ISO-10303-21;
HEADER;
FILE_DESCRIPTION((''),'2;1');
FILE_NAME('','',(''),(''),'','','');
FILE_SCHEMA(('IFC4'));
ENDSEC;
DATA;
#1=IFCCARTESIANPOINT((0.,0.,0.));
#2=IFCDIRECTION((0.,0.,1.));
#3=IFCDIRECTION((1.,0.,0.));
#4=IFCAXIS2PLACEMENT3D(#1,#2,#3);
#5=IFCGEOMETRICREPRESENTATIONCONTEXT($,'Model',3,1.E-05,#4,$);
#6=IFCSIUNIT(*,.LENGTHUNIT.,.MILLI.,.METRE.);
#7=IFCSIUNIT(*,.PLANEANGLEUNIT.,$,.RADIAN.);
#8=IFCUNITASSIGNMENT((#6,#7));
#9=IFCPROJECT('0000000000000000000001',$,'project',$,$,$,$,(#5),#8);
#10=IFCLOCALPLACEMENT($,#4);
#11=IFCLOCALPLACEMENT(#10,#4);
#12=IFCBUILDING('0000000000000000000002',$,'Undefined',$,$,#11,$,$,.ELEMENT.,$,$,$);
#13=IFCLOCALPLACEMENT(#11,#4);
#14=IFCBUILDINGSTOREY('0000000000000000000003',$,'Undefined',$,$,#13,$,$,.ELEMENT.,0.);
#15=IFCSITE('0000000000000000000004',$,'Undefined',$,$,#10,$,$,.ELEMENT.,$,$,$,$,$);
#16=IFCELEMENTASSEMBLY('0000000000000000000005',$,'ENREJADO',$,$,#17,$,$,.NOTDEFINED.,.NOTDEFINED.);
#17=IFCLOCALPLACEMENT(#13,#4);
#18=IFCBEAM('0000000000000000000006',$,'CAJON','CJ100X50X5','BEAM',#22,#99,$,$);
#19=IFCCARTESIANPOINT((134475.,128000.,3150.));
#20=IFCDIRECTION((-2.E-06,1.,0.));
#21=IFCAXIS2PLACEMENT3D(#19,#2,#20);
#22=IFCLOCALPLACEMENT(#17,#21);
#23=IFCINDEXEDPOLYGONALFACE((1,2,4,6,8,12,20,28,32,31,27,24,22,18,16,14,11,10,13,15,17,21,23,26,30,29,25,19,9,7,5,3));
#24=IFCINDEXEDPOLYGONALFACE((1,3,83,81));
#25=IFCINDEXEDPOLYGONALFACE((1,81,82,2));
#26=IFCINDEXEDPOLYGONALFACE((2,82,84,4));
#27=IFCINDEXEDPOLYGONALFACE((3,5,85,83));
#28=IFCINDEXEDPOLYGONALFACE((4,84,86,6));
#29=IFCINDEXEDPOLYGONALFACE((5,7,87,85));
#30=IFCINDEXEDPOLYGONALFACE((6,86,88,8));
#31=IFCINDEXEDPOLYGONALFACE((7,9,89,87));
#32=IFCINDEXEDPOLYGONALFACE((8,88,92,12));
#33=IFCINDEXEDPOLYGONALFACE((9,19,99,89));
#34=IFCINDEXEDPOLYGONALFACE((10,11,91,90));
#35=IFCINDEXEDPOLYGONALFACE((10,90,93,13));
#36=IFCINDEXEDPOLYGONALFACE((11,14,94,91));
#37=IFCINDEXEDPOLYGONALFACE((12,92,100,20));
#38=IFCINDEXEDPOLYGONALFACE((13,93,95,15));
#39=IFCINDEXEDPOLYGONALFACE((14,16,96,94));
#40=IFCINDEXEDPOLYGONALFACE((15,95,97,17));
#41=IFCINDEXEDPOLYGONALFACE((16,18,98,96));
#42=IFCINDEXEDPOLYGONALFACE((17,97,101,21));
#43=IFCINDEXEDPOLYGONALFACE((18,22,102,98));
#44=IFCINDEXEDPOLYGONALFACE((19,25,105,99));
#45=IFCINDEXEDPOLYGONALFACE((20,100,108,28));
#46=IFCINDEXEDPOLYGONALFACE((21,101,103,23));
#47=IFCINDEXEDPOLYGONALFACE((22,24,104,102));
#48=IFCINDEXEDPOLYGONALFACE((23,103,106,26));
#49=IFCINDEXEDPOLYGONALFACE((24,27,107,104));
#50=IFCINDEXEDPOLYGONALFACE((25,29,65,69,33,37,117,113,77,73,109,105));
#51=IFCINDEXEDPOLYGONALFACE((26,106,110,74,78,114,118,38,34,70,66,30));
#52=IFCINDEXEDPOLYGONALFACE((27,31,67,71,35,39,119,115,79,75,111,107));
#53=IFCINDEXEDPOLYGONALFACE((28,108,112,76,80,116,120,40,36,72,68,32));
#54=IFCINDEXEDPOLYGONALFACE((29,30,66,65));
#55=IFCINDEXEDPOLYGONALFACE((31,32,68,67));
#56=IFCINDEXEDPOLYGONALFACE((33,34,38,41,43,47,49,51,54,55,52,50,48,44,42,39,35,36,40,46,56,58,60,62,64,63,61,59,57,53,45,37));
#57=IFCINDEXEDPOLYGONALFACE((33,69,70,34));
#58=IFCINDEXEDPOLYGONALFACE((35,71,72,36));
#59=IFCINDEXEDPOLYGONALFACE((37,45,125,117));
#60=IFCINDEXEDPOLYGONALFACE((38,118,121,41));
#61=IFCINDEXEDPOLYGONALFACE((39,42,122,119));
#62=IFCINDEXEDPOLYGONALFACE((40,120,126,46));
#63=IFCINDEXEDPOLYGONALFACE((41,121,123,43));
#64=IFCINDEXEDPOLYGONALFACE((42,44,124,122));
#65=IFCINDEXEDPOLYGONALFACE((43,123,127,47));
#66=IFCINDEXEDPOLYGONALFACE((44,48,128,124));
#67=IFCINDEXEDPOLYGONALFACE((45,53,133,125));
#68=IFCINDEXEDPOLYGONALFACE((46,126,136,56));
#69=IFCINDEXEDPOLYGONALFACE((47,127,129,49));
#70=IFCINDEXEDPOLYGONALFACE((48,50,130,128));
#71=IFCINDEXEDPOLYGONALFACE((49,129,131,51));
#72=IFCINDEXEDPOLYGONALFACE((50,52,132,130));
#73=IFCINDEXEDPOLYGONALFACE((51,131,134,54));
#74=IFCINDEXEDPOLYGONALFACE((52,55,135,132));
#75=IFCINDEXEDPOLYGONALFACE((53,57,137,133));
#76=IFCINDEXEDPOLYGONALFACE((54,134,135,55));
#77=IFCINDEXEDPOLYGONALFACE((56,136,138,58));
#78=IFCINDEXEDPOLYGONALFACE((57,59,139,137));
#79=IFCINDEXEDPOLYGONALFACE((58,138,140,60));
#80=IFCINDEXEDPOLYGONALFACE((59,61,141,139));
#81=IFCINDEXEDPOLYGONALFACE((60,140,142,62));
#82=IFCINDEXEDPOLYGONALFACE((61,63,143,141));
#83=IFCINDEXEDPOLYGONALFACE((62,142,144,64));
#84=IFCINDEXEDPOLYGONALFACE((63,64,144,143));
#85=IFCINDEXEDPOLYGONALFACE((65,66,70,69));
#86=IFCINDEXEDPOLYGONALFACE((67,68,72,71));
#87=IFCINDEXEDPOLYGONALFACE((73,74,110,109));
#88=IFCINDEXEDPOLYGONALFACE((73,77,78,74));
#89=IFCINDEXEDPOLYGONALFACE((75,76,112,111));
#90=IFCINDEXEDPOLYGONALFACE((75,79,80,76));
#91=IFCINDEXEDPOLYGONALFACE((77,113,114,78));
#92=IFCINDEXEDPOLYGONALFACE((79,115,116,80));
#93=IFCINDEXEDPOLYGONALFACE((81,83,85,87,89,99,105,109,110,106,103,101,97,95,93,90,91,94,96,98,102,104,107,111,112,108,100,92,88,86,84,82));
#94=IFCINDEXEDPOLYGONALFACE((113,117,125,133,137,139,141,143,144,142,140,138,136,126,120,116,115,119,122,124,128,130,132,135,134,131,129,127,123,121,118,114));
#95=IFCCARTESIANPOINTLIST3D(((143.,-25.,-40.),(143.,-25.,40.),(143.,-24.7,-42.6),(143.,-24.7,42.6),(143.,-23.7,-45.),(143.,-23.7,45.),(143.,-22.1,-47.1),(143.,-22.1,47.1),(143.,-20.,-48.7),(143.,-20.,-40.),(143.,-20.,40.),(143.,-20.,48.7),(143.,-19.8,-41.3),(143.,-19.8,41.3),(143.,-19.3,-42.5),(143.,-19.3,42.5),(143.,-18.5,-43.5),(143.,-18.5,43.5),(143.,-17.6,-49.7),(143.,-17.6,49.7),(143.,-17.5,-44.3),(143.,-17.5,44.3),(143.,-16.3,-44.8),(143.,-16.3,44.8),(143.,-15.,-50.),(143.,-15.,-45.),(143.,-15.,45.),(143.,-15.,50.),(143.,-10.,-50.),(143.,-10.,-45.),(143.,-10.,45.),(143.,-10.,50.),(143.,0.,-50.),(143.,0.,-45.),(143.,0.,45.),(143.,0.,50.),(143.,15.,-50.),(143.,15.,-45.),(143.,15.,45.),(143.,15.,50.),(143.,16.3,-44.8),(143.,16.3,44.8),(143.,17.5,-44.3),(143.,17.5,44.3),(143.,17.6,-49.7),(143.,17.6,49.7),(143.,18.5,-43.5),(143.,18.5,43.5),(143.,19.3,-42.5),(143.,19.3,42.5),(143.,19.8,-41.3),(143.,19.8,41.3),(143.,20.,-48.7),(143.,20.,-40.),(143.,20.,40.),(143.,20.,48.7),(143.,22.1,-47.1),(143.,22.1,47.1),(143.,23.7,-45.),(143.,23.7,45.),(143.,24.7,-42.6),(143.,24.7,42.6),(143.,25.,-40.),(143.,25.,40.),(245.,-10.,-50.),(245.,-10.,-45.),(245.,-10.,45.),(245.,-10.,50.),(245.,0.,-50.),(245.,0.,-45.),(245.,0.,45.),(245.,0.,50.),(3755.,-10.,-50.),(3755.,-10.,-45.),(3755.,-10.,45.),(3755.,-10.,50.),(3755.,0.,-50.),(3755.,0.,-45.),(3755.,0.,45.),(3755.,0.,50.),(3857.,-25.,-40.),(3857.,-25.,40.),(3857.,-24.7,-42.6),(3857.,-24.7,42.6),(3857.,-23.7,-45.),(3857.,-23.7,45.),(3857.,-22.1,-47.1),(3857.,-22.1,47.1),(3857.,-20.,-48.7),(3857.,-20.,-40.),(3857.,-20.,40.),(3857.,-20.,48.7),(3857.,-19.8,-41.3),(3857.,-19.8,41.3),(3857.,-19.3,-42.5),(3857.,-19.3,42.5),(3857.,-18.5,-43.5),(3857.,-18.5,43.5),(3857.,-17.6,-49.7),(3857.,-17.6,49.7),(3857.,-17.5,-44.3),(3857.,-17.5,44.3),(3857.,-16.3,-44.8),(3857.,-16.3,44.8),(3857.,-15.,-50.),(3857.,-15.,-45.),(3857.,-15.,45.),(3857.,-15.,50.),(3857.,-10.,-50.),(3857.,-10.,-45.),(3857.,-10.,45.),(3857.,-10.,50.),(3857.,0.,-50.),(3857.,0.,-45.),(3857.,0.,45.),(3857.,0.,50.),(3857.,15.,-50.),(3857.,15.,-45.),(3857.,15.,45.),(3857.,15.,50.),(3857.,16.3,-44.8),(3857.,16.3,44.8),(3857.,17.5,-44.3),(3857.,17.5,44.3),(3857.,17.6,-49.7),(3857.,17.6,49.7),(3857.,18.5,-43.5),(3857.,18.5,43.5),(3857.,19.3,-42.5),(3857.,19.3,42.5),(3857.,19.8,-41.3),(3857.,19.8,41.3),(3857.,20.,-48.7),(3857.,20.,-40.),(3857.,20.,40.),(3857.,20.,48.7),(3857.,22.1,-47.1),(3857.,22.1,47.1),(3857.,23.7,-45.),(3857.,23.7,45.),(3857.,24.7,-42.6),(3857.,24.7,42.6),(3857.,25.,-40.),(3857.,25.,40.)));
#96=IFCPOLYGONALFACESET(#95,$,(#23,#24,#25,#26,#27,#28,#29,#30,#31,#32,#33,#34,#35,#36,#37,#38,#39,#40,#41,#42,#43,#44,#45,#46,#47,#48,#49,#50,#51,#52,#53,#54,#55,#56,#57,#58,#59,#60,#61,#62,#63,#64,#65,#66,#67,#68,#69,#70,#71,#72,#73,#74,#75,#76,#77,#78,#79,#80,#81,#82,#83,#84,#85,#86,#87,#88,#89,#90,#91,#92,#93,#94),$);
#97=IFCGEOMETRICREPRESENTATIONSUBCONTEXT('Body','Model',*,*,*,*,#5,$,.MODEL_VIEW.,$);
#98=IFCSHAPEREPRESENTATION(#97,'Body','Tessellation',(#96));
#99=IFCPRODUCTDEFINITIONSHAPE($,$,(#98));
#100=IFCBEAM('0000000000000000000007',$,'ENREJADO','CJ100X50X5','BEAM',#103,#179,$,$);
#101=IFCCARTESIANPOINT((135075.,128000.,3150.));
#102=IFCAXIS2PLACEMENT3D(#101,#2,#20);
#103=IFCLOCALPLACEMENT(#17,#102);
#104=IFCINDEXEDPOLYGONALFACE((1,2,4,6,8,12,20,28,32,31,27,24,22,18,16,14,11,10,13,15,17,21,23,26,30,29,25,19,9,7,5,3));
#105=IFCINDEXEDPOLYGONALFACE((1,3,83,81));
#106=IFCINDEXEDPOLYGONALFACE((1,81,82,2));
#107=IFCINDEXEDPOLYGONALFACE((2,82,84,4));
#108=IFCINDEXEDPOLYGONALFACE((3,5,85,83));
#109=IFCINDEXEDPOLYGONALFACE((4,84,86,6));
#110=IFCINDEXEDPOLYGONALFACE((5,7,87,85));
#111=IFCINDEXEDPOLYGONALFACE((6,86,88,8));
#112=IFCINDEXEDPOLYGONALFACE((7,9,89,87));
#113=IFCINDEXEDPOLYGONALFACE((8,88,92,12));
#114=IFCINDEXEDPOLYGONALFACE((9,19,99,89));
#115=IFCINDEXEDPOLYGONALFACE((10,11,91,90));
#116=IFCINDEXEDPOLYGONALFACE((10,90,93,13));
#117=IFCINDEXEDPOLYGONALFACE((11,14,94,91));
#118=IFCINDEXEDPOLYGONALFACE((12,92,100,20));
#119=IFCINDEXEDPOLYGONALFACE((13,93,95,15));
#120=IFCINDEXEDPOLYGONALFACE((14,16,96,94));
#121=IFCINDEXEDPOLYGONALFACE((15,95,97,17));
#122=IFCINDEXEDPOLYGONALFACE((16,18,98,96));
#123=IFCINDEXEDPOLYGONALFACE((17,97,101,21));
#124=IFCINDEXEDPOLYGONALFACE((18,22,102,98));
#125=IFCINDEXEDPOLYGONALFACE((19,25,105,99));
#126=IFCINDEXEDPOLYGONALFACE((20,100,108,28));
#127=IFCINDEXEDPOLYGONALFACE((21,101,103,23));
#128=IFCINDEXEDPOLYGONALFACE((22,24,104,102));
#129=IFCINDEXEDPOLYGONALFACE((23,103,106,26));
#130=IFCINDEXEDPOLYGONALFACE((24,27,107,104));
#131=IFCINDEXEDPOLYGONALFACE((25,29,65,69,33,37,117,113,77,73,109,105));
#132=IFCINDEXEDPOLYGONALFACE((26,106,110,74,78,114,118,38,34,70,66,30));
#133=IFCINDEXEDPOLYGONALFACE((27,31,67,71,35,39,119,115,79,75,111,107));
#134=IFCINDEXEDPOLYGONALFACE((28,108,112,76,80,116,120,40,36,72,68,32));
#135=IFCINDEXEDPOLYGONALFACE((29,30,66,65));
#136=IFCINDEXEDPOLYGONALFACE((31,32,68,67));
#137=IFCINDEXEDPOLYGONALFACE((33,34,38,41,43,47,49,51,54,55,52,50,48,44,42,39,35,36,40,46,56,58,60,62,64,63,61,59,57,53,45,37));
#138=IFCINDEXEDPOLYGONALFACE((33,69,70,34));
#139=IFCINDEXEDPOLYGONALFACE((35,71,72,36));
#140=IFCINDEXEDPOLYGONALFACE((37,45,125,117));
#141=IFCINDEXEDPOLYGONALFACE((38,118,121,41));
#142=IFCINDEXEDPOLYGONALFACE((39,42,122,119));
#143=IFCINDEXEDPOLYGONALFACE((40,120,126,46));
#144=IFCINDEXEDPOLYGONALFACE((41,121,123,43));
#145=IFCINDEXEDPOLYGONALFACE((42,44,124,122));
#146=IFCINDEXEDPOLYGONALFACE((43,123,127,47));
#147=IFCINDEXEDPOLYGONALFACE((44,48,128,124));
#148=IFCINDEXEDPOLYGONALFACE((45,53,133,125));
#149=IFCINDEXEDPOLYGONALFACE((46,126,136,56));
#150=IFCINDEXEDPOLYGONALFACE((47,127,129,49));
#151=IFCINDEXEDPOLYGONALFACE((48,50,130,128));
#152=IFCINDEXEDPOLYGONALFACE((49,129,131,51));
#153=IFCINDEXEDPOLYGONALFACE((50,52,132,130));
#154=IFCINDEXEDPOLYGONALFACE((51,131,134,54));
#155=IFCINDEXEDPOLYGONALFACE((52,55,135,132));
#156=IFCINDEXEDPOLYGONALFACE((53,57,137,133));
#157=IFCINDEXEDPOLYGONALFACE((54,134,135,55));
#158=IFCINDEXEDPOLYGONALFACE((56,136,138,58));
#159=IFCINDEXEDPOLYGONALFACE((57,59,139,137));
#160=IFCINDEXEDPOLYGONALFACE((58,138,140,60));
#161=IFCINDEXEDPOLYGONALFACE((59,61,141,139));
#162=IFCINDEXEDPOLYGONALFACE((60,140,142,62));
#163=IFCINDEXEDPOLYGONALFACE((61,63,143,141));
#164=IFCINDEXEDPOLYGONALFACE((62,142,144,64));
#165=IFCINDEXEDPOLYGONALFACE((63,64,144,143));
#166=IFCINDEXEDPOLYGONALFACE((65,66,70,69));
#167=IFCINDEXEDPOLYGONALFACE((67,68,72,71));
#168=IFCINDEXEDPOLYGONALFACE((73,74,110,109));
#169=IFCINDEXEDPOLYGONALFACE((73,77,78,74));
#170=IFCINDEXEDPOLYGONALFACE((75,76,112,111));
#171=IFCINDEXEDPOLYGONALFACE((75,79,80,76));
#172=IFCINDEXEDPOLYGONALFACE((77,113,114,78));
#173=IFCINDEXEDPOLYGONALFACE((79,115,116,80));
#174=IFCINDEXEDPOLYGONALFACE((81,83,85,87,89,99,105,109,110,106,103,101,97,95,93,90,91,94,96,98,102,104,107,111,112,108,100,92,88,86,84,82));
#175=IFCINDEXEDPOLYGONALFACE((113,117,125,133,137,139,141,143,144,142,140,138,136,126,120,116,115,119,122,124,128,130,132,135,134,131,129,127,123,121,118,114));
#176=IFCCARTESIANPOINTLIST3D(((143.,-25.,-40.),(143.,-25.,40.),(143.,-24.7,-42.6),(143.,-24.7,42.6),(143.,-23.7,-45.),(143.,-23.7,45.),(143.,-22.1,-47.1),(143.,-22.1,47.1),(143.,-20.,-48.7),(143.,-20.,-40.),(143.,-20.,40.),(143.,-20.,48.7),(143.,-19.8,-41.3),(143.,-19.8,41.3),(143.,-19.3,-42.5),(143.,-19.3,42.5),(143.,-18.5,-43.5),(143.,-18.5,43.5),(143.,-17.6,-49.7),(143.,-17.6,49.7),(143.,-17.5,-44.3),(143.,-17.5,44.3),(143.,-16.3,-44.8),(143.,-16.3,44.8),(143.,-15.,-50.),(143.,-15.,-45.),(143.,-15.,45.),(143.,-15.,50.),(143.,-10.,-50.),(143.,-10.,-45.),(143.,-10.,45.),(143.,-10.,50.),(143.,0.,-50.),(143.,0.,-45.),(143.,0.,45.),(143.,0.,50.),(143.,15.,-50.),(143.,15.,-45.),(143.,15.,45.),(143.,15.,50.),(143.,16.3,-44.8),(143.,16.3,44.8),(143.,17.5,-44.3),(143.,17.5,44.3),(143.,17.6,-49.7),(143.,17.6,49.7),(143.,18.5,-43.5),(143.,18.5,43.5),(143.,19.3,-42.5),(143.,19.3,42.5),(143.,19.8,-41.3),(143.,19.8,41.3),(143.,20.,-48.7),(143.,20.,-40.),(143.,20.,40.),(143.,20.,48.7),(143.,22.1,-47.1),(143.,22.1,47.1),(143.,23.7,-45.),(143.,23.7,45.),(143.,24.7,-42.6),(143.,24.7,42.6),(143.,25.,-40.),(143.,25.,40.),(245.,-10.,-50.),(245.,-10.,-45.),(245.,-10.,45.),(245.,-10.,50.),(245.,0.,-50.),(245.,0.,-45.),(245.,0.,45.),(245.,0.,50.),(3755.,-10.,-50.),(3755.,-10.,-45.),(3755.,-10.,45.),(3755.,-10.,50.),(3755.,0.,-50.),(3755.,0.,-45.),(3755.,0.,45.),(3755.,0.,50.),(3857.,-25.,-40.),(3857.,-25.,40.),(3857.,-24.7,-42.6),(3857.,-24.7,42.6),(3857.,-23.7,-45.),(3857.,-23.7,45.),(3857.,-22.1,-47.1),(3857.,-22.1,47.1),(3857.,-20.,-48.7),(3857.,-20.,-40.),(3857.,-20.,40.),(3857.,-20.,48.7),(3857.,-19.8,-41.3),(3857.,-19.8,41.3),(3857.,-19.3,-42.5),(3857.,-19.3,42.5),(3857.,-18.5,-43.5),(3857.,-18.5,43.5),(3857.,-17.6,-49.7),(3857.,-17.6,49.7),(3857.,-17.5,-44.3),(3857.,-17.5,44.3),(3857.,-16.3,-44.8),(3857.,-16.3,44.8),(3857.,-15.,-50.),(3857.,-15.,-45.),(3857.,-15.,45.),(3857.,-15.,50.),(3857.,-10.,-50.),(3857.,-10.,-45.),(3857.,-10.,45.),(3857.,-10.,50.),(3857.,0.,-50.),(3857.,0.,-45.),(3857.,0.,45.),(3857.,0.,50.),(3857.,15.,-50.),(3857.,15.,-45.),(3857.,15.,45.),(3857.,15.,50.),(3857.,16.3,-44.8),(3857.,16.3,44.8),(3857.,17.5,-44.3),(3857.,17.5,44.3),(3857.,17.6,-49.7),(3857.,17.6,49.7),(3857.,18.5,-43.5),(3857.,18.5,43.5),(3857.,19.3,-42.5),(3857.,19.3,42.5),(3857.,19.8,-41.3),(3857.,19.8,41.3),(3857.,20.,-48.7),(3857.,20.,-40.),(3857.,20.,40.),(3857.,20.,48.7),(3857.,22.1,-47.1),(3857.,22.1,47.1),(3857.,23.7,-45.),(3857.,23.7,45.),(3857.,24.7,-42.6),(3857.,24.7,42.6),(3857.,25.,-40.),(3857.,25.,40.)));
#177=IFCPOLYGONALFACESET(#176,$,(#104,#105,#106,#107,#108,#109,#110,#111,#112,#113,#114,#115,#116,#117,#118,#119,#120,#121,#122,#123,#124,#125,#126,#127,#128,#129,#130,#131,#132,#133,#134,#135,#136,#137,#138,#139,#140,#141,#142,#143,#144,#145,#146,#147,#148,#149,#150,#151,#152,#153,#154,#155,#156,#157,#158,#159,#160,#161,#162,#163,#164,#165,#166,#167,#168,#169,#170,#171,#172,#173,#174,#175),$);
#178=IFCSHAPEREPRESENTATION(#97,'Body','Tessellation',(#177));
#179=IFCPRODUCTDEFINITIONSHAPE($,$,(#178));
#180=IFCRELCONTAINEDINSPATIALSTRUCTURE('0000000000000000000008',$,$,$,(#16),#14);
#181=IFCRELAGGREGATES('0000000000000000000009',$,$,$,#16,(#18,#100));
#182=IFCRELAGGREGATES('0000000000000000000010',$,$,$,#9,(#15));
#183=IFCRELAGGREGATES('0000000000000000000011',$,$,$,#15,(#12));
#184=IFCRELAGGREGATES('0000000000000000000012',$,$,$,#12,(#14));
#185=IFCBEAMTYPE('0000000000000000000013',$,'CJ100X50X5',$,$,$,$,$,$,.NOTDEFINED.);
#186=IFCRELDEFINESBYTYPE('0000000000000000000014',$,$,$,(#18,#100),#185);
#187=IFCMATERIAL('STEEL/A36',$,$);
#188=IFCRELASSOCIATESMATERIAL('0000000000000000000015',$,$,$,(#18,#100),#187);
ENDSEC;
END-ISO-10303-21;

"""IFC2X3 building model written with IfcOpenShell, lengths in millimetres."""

from ifc_helpers import new_model, si_unit, frame, origin_with_axes, origin_2d_with_axis, place, context, subcontext, project, spatial, rectangle, hollow_rectangle, extrude, boolean, halfspace, material, type_object, element, aggregate, save


model = new_model("IFC2X3")

# Units and contexts
model_context = context("Model", 3, precision=1e-05, world=origin_with_axes())
body_context = subcontext(model_context, "Body", "Model", "MODEL_VIEW")
ifc_project = project(units=[si_unit("LENGTHUNIT", "METRE", prefix="MILLI"), si_unit("PLANEANGLEUNIT", "RADIAN")], contexts=[model_context])

# Site, building, storey
site_placement = place(None, origin_with_axes())
site = spatial("IfcSite", under=ifc_project, at=site_placement, Name="Undefined", CompositionType="ELEMENT")
building_placement = place(site_placement, origin_with_axes())
building = spatial("IfcBuilding", under=site, at=building_placement, Name="Undefined", CompositionType="ELEMENT")
storey_placement = place(building_placement, origin_with_axes())
storey = spatial("IfcBuildingStorey", under=building, at=storey_placement, Name="Undefined", CompositionType="ELEMENT", Elevation=0.0)

# Shared definitions
ifc_material_1 = material(Name="STEEL/A36")

# Element assembly, beams
assembly_1_placement = place(storey_placement, origin_with_axes())
assembly_1 = element("IfcElementAssembly", 1, at=assembly_1_placement, inside=storey, Name="ENREJADO", AssemblyPlace="NOTDEFINED", PredefinedType="NOTDEFINED")
beam_type_1 = type_object("IfcBeamType", Name="CJ100X50X5", PredefinedType="NOTDEFINED")
beam_1_placement = place(assembly_1_placement, frame((134475.0, 128000.0, 3150.0), z_axis=(0.0, 0.0, 1.0), x_axis=(-0.000002, 1.0, 0.0)))
beam_1 = element("IfcBeam", 2, at=beam_1_placement, type_object=beam_type_1, material=ifc_material_1, Name="CAJON", Description="CJ100X50X5", ObjectType="BEAM", context=body_context, shape_type="CSG", body=[
    boolean("DIFFERENCE", boolean("DIFFERENCE", boolean("DIFFERENCE", boolean("DIFFERENCE", extrude(hollow_rectangle(XDim=50.0, YDim=100.0, WallThickness=5.0, InnerFilletRadius=5.0, OuterFilletRadius=10.0, at=origin_2d_with_axis()), frame((4000.0, 0.0, 0.0), z_axis=(-1.0, 0.0, 0.0), x_axis=(0.0, -1.0, 0.0)), (0.0, 0.0, 1.0), 4000.0), extrude(rectangle(XDim=10.0, YDim=104.0, at=origin_2d_with_axis()), frame((3755.0, -5.0, 0.0), z_axis=(1.0, 0.0, 0.0), x_axis=(0.0, 1.0, 0.0)), (0.0, 0.0, 1.0), 120.0)), extrude(rectangle(XDim=10.0, YDim=104.0, at=origin_2d_with_axis()), frame((245.0, -5.0, 0.0), z_axis=(-1.0, 0.000003, 0.0), x_axis=(0.000002, 1.0, 0.0)), (0.0, 0.0, 1.0), 120.0)), halfspace(frame((3857.0, 200.0, 50.0), z_axis=(-1.0, 0.0, 0.0), x_axis=(0.0, -1.0, 0.0)), True)), halfspace(frame((143.0, 200.0, -50.0), z_axis=(1.0, -0.000003, 0.0), x_axis=(-0.000002, -1.0, 0.0)), True)),
])
beam_2_placement = place(assembly_1_placement, frame((135075.0, 128000.0, 3150.0), z_axis=(0.0, 0.0, 1.0), x_axis=(-0.000002, 1.0, 0.0)))
beam_2 = element("IfcBeam", 3, at=beam_2_placement, type_object=beam_type_1, material=ifc_material_1, Name="ENREJADO", Description="CJ100X50X5", ObjectType="BEAM", context=body_context, shape_type="CSG", body=[
    boolean("DIFFERENCE", boolean("DIFFERENCE", boolean("DIFFERENCE", boolean("DIFFERENCE", extrude(hollow_rectangle(XDim=50.0, YDim=100.0, WallThickness=5.0, InnerFilletRadius=5.0, OuterFilletRadius=10.0, at=origin_2d_with_axis()), frame((4000.0, 0.0, 0.0), z_axis=(-1.0, 0.0, 0.0), x_axis=(0.0, -1.0, 0.0)), (0.0, 0.0, 1.0), 4000.0), extrude(rectangle(XDim=10.0, YDim=104.0, at=origin_2d_with_axis()), frame((3755.0, -5.0, 0.0), z_axis=(1.0, 0.0, 0.0), x_axis=(0.0, 1.0, 0.0)), (0.0, 0.0, 1.0), 120.0)), extrude(rectangle(XDim=10.0, YDim=104.0, at=origin_2d_with_axis()), frame((245.0, -5.0, 0.0), z_axis=(-1.0, 0.000003, 0.0), x_axis=(0.000002, 1.0, 0.0)), (0.0, 0.0, 1.0), 120.0)), halfspace(frame((3857.0, 200.0, 50.0), z_axis=(-1.0, 0.0, 0.0), x_axis=(0.0, -1.0, 0.0)), True)), halfspace(frame((143.0, 200.0, -50.0), z_axis=(1.0, -0.000003, 0.0), x_axis=(-0.000002, -1.0, 0.0)), True)),
])

aggregate(assembly_1, [beam_1, beam_2])

save(model, "model.ifc")
